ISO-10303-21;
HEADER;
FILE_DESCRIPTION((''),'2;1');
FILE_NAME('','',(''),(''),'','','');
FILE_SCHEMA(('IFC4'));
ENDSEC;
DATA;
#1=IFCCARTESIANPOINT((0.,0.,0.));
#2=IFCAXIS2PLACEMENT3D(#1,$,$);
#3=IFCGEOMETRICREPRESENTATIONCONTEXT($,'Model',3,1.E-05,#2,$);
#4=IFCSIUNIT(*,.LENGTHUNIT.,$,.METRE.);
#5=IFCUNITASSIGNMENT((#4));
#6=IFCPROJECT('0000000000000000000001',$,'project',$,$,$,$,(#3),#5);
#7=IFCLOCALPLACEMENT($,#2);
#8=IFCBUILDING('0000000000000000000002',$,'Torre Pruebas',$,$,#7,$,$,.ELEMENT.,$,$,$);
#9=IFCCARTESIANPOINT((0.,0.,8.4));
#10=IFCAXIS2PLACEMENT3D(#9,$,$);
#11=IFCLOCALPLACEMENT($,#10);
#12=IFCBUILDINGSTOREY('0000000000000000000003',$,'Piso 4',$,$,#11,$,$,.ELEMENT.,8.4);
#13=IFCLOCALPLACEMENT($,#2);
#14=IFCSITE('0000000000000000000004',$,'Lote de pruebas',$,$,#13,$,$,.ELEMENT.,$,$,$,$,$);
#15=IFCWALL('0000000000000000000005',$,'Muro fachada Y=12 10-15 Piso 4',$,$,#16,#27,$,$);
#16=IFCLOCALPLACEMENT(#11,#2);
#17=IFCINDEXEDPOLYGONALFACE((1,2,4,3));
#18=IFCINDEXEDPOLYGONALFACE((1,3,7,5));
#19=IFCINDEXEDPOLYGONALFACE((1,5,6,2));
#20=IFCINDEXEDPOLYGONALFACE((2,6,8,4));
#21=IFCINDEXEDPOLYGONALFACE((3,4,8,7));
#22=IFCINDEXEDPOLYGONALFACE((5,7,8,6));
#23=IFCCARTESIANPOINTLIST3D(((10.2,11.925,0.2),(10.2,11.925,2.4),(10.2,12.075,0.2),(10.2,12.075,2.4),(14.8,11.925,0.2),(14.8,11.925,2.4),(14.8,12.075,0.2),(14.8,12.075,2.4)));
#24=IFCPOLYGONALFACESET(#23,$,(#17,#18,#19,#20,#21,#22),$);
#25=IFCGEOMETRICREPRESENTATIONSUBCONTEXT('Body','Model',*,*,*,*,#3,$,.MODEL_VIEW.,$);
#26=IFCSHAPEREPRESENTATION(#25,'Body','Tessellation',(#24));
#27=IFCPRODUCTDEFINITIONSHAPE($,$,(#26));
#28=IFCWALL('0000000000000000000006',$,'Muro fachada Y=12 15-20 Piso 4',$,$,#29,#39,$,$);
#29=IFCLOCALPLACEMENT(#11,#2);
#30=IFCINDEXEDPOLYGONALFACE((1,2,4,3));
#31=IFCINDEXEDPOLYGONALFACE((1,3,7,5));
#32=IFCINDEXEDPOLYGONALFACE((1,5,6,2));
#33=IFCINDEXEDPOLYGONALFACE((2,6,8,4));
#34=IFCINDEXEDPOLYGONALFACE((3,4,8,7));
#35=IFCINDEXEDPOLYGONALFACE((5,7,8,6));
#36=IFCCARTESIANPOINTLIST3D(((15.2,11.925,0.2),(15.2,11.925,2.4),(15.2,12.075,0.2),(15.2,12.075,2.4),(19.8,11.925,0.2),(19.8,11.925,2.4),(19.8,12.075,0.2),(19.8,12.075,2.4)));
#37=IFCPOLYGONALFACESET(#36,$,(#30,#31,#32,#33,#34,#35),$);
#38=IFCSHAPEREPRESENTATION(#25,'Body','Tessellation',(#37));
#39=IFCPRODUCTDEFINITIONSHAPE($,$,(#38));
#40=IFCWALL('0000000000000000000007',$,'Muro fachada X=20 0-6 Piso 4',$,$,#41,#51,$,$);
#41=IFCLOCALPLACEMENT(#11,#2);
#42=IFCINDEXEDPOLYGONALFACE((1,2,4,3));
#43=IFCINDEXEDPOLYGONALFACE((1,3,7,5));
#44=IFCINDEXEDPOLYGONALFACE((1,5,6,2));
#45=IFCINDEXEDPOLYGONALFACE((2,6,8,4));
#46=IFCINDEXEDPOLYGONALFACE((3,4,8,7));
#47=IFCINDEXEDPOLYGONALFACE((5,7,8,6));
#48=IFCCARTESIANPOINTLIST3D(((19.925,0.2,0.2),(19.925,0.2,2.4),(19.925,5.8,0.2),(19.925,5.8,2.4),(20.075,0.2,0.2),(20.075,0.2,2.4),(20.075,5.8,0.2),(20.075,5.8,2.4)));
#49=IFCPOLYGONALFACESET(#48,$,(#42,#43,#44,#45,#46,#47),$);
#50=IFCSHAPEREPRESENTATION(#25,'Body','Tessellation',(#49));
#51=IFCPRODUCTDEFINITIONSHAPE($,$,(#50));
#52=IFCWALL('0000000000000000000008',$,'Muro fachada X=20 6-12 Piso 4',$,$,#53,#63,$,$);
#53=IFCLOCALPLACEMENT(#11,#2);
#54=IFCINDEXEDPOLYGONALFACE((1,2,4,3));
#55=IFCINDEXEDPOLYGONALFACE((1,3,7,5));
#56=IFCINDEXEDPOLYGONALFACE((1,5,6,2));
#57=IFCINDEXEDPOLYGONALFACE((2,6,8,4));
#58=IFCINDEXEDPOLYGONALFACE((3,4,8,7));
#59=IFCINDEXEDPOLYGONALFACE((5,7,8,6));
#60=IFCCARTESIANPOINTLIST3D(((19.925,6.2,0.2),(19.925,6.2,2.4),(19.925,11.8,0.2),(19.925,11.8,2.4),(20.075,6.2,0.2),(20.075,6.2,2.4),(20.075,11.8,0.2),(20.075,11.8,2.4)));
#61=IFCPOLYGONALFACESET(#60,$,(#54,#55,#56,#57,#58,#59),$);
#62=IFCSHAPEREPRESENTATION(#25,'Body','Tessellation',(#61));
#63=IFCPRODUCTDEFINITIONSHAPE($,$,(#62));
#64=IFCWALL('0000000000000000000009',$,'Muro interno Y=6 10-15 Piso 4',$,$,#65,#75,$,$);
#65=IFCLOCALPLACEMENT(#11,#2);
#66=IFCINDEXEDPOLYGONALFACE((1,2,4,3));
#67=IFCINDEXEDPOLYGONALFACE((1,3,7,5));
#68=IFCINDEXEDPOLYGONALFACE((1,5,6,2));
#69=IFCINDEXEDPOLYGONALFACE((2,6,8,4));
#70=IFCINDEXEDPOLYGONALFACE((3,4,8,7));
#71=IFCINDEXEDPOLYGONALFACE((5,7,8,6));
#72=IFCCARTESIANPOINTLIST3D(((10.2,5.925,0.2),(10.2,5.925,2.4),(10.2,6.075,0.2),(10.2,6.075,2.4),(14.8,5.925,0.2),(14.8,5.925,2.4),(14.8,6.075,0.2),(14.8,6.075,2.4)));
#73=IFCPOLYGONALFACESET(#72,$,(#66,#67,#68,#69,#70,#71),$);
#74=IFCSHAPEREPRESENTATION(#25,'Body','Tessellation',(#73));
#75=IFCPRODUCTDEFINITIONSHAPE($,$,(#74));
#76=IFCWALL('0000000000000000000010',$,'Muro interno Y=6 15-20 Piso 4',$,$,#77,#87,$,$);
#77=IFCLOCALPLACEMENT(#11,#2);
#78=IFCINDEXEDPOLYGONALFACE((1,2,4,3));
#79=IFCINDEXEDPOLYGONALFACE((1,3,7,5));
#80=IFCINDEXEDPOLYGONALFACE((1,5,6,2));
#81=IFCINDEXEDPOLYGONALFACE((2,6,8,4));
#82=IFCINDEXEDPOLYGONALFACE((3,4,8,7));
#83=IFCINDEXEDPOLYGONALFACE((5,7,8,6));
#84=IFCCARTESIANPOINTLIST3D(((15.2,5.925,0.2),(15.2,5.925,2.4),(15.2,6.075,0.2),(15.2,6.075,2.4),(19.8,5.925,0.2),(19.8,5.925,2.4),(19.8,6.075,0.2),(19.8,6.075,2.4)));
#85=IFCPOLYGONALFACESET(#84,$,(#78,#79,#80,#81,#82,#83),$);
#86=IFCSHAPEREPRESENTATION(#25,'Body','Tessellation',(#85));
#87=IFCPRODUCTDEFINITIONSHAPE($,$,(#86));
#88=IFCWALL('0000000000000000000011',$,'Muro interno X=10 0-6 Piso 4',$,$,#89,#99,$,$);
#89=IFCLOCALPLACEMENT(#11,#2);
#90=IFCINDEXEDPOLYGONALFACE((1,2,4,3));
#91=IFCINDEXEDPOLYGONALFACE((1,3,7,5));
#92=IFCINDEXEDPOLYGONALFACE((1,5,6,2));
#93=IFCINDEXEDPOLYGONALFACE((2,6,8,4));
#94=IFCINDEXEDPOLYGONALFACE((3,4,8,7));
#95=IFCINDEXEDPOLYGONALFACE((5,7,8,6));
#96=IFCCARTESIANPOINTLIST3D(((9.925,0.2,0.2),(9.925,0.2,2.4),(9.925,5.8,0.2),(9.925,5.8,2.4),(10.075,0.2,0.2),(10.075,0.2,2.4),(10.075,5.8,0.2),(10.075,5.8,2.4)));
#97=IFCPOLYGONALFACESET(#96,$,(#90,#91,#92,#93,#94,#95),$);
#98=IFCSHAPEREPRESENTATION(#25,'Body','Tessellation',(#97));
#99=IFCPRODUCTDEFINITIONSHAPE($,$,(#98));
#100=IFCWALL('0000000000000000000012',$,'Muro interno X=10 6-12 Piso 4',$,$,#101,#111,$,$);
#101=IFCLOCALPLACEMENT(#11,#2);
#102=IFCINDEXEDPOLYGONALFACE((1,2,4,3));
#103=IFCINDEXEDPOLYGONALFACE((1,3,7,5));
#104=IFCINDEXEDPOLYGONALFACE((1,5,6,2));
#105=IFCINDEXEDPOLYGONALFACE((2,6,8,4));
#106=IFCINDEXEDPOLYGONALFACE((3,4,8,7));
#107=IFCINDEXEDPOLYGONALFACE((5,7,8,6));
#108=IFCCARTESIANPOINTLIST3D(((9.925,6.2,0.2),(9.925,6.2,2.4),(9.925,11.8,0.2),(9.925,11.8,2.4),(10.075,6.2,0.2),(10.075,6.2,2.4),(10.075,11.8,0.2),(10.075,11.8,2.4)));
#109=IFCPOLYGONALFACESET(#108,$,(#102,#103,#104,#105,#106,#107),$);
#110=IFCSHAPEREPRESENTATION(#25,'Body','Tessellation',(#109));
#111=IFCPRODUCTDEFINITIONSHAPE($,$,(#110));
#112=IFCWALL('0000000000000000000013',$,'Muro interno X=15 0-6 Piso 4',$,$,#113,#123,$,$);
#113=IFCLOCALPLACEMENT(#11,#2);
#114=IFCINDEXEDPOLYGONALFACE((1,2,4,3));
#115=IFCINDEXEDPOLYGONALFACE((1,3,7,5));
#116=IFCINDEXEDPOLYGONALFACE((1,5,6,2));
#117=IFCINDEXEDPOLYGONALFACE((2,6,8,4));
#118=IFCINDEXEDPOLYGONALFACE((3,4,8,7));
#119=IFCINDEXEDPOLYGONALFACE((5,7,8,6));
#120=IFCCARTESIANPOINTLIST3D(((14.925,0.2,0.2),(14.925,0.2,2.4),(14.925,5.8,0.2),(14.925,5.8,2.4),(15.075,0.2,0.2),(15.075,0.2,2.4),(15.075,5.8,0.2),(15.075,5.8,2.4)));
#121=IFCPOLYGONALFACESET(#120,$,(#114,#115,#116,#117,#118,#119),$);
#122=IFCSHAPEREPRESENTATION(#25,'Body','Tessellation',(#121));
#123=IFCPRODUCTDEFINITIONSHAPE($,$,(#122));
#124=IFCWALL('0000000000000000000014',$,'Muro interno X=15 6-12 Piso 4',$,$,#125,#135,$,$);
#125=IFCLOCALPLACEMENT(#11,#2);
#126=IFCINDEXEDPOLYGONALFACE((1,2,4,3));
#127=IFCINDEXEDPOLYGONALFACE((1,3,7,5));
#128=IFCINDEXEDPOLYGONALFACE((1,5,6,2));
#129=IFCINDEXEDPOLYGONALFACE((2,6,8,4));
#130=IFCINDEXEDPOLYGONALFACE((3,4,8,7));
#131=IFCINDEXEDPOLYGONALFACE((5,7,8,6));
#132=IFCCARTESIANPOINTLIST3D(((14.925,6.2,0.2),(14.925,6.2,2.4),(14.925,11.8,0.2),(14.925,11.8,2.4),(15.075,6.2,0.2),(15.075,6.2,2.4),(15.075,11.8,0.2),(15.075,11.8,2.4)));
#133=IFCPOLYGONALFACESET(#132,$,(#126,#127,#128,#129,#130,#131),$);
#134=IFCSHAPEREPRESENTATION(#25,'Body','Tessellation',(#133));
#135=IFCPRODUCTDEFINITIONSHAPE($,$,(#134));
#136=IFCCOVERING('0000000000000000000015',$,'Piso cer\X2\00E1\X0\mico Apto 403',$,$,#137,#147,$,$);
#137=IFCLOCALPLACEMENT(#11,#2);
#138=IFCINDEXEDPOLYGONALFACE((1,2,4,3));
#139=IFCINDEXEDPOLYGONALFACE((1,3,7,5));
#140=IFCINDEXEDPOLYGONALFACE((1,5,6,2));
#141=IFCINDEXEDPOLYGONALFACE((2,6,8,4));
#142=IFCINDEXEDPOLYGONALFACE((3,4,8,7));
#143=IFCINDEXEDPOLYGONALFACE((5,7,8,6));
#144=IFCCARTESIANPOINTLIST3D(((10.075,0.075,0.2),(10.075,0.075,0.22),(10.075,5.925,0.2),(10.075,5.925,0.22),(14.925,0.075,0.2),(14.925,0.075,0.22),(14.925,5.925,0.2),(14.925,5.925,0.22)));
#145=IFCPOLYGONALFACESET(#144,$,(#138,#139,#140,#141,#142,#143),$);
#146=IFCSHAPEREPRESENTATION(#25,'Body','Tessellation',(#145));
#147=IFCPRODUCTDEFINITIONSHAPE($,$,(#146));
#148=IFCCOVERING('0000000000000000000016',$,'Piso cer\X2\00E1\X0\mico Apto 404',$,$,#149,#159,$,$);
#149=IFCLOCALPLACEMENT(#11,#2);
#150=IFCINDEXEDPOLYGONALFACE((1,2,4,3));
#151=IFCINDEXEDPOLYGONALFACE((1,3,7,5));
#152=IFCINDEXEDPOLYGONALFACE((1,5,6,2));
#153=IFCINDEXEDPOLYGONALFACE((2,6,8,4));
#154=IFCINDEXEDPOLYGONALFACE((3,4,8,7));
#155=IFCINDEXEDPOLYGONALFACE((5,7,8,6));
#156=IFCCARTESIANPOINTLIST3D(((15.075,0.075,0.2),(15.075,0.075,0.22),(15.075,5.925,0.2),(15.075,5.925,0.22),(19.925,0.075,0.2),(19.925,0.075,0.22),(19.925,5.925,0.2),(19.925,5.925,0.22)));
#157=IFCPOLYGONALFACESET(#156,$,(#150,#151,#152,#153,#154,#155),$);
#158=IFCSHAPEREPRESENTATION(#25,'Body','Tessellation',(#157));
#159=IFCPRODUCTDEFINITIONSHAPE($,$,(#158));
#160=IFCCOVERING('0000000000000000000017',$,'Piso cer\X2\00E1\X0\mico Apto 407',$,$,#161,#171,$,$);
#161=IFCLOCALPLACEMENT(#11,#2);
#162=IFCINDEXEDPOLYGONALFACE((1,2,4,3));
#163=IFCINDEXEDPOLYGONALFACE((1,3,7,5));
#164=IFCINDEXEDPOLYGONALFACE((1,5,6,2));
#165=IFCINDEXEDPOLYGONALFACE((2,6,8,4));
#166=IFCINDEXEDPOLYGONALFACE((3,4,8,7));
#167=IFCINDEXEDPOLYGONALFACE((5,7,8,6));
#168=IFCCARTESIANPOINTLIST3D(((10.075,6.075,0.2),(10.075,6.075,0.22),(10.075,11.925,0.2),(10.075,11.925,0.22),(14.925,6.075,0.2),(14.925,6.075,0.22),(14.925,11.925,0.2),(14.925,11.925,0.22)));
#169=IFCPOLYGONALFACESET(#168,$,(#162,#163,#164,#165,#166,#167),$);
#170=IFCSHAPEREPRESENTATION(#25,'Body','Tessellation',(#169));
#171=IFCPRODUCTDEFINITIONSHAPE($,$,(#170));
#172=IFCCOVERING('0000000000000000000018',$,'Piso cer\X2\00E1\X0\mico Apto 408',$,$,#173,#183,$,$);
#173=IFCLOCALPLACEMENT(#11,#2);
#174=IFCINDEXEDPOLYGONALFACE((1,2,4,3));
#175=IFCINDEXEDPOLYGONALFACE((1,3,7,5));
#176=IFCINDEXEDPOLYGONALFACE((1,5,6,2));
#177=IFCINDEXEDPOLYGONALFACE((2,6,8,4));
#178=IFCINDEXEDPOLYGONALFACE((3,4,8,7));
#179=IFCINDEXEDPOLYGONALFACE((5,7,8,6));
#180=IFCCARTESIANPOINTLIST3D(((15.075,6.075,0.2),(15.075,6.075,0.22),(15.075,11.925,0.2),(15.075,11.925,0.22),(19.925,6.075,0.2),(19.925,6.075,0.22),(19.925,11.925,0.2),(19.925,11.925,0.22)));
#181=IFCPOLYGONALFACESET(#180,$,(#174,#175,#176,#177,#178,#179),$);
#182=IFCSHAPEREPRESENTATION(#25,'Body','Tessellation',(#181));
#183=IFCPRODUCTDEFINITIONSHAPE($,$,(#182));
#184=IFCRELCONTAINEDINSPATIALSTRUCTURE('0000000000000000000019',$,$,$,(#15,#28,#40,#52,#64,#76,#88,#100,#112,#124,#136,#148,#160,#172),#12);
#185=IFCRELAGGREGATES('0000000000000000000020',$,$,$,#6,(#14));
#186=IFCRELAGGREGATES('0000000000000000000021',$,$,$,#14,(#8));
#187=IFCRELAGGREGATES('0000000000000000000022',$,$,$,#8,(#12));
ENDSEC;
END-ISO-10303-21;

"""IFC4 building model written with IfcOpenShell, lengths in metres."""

from ifc_helpers import new_model, si_unit, frame, origin, origin_2d, place, context, subcontext, project, spatial, rectangle, extrude, element, save


model = new_model("IFC4")

# Units and contexts
model_context = context("Model", 3, precision=1e-05, world=origin())
body_context = subcontext(model_context, "Body", "Model", "MODEL_VIEW")
ifc_project = project(units=[si_unit("LENGTHUNIT", "METRE")], contexts=[model_context])

# Site, building, storey
site_placement = place(None, origin())
site = spatial("IfcSite", under=ifc_project, at=site_placement, Name="Lote de pruebas", CompositionType="ELEMENT")
building_placement = place(None, origin())
building = spatial("IfcBuilding", under=site, at=building_placement, Name="Torre Pruebas", CompositionType="ELEMENT")
storey_placement = place(None, frame((0.0, 0.0, 8.4)))
storey = spatial("IfcBuildingStorey", under=building, at=storey_placement, Name="Piso 4", CompositionType="ELEMENT", Elevation=8.4)

# Walls
for number, where, name in (
    (1, (12.5, 12.0, 8.6), "Muro fachada Y=12 10-15 Piso 4"),
    (2, (17.5, 12.0, 8.6), "Muro fachada Y=12 15-20 Piso 4"),
):
    element("IfcWall", number, at=place(None, frame(where)), inside=storey, Name=name, context=body_context, shape_type="SweptSolid", body=[
        extrude(rectangle(XDim=4.6, YDim=0.15, at=origin_2d()), origin(), (0.0, 0.0, 1.0), 2.2),
    ])
for number, where, name in (
    (3, (20.0, 3.0, 8.6), "Muro fachada X=20 0-6 Piso 4"),
    (4, (20.0, 9.0, 8.6), "Muro fachada X=20 6-12 Piso 4"),
):
    element("IfcWall", number, at=place(None, frame(where)), inside=storey, Name=name, context=body_context, shape_type="SweptSolid", body=[
        extrude(rectangle(XDim=0.15, YDim=5.6, at=origin_2d()), origin(), (0.0, 0.0, 1.0), 2.2),
    ])
for number, where, name in (
    (5, (12.5, 6.0, 8.6), "Muro interno Y=6 10-15 Piso 4"),
    (6, (17.5, 6.0, 8.6), "Muro interno Y=6 15-20 Piso 4"),
):
    element("IfcWall", number, at=place(None, frame(where)), inside=storey, Name=name, context=body_context, shape_type="SweptSolid", body=[
        extrude(rectangle(XDim=4.6, YDim=0.15, at=origin_2d()), origin(), (0.0, 0.0, 1.0), 2.2),
    ])
for number, where, name in (
    (7, (10.0, 3.0, 8.6), "Muro interno X=10 0-6 Piso 4"),
    (8, (10.0, 9.0, 8.6), "Muro interno X=10 6-12 Piso 4"),
    (9, (15.0, 3.0, 8.6), "Muro interno X=15 0-6 Piso 4"),
    (10, (15.0, 9.0, 8.6), "Muro interno X=15 6-12 Piso 4"),
):
    element("IfcWall", number, at=place(None, frame(where)), inside=storey, Name=name, context=body_context, shape_type="SweptSolid", body=[
        extrude(rectangle(XDim=0.15, YDim=5.6, at=origin_2d()), origin(), (0.0, 0.0, 1.0), 2.2),
    ])

# Coverings
for number, where, name in (
    (11, (12.5, 3.0, 8.6), "Piso cerámico Apto 403"),
    (12, (17.5, 3.0, 8.6), "Piso cerámico Apto 404"),
    (13, (12.5, 9.0, 8.6), "Piso cerámico Apto 407"),
    (14, (17.5, 9.0, 8.6), "Piso cerámico Apto 408"),
):
    element("IfcCovering", number, at=place(None, frame(where)), inside=storey, Name=name, context=body_context, shape_type="SweptSolid", body=[
        extrude(rectangle(XDim=4.85, YDim=5.85, at=origin_2d()), origin(), (0.0, 0.0, 1.0), 0.02),
    ])

save(model, "model.ifc")
